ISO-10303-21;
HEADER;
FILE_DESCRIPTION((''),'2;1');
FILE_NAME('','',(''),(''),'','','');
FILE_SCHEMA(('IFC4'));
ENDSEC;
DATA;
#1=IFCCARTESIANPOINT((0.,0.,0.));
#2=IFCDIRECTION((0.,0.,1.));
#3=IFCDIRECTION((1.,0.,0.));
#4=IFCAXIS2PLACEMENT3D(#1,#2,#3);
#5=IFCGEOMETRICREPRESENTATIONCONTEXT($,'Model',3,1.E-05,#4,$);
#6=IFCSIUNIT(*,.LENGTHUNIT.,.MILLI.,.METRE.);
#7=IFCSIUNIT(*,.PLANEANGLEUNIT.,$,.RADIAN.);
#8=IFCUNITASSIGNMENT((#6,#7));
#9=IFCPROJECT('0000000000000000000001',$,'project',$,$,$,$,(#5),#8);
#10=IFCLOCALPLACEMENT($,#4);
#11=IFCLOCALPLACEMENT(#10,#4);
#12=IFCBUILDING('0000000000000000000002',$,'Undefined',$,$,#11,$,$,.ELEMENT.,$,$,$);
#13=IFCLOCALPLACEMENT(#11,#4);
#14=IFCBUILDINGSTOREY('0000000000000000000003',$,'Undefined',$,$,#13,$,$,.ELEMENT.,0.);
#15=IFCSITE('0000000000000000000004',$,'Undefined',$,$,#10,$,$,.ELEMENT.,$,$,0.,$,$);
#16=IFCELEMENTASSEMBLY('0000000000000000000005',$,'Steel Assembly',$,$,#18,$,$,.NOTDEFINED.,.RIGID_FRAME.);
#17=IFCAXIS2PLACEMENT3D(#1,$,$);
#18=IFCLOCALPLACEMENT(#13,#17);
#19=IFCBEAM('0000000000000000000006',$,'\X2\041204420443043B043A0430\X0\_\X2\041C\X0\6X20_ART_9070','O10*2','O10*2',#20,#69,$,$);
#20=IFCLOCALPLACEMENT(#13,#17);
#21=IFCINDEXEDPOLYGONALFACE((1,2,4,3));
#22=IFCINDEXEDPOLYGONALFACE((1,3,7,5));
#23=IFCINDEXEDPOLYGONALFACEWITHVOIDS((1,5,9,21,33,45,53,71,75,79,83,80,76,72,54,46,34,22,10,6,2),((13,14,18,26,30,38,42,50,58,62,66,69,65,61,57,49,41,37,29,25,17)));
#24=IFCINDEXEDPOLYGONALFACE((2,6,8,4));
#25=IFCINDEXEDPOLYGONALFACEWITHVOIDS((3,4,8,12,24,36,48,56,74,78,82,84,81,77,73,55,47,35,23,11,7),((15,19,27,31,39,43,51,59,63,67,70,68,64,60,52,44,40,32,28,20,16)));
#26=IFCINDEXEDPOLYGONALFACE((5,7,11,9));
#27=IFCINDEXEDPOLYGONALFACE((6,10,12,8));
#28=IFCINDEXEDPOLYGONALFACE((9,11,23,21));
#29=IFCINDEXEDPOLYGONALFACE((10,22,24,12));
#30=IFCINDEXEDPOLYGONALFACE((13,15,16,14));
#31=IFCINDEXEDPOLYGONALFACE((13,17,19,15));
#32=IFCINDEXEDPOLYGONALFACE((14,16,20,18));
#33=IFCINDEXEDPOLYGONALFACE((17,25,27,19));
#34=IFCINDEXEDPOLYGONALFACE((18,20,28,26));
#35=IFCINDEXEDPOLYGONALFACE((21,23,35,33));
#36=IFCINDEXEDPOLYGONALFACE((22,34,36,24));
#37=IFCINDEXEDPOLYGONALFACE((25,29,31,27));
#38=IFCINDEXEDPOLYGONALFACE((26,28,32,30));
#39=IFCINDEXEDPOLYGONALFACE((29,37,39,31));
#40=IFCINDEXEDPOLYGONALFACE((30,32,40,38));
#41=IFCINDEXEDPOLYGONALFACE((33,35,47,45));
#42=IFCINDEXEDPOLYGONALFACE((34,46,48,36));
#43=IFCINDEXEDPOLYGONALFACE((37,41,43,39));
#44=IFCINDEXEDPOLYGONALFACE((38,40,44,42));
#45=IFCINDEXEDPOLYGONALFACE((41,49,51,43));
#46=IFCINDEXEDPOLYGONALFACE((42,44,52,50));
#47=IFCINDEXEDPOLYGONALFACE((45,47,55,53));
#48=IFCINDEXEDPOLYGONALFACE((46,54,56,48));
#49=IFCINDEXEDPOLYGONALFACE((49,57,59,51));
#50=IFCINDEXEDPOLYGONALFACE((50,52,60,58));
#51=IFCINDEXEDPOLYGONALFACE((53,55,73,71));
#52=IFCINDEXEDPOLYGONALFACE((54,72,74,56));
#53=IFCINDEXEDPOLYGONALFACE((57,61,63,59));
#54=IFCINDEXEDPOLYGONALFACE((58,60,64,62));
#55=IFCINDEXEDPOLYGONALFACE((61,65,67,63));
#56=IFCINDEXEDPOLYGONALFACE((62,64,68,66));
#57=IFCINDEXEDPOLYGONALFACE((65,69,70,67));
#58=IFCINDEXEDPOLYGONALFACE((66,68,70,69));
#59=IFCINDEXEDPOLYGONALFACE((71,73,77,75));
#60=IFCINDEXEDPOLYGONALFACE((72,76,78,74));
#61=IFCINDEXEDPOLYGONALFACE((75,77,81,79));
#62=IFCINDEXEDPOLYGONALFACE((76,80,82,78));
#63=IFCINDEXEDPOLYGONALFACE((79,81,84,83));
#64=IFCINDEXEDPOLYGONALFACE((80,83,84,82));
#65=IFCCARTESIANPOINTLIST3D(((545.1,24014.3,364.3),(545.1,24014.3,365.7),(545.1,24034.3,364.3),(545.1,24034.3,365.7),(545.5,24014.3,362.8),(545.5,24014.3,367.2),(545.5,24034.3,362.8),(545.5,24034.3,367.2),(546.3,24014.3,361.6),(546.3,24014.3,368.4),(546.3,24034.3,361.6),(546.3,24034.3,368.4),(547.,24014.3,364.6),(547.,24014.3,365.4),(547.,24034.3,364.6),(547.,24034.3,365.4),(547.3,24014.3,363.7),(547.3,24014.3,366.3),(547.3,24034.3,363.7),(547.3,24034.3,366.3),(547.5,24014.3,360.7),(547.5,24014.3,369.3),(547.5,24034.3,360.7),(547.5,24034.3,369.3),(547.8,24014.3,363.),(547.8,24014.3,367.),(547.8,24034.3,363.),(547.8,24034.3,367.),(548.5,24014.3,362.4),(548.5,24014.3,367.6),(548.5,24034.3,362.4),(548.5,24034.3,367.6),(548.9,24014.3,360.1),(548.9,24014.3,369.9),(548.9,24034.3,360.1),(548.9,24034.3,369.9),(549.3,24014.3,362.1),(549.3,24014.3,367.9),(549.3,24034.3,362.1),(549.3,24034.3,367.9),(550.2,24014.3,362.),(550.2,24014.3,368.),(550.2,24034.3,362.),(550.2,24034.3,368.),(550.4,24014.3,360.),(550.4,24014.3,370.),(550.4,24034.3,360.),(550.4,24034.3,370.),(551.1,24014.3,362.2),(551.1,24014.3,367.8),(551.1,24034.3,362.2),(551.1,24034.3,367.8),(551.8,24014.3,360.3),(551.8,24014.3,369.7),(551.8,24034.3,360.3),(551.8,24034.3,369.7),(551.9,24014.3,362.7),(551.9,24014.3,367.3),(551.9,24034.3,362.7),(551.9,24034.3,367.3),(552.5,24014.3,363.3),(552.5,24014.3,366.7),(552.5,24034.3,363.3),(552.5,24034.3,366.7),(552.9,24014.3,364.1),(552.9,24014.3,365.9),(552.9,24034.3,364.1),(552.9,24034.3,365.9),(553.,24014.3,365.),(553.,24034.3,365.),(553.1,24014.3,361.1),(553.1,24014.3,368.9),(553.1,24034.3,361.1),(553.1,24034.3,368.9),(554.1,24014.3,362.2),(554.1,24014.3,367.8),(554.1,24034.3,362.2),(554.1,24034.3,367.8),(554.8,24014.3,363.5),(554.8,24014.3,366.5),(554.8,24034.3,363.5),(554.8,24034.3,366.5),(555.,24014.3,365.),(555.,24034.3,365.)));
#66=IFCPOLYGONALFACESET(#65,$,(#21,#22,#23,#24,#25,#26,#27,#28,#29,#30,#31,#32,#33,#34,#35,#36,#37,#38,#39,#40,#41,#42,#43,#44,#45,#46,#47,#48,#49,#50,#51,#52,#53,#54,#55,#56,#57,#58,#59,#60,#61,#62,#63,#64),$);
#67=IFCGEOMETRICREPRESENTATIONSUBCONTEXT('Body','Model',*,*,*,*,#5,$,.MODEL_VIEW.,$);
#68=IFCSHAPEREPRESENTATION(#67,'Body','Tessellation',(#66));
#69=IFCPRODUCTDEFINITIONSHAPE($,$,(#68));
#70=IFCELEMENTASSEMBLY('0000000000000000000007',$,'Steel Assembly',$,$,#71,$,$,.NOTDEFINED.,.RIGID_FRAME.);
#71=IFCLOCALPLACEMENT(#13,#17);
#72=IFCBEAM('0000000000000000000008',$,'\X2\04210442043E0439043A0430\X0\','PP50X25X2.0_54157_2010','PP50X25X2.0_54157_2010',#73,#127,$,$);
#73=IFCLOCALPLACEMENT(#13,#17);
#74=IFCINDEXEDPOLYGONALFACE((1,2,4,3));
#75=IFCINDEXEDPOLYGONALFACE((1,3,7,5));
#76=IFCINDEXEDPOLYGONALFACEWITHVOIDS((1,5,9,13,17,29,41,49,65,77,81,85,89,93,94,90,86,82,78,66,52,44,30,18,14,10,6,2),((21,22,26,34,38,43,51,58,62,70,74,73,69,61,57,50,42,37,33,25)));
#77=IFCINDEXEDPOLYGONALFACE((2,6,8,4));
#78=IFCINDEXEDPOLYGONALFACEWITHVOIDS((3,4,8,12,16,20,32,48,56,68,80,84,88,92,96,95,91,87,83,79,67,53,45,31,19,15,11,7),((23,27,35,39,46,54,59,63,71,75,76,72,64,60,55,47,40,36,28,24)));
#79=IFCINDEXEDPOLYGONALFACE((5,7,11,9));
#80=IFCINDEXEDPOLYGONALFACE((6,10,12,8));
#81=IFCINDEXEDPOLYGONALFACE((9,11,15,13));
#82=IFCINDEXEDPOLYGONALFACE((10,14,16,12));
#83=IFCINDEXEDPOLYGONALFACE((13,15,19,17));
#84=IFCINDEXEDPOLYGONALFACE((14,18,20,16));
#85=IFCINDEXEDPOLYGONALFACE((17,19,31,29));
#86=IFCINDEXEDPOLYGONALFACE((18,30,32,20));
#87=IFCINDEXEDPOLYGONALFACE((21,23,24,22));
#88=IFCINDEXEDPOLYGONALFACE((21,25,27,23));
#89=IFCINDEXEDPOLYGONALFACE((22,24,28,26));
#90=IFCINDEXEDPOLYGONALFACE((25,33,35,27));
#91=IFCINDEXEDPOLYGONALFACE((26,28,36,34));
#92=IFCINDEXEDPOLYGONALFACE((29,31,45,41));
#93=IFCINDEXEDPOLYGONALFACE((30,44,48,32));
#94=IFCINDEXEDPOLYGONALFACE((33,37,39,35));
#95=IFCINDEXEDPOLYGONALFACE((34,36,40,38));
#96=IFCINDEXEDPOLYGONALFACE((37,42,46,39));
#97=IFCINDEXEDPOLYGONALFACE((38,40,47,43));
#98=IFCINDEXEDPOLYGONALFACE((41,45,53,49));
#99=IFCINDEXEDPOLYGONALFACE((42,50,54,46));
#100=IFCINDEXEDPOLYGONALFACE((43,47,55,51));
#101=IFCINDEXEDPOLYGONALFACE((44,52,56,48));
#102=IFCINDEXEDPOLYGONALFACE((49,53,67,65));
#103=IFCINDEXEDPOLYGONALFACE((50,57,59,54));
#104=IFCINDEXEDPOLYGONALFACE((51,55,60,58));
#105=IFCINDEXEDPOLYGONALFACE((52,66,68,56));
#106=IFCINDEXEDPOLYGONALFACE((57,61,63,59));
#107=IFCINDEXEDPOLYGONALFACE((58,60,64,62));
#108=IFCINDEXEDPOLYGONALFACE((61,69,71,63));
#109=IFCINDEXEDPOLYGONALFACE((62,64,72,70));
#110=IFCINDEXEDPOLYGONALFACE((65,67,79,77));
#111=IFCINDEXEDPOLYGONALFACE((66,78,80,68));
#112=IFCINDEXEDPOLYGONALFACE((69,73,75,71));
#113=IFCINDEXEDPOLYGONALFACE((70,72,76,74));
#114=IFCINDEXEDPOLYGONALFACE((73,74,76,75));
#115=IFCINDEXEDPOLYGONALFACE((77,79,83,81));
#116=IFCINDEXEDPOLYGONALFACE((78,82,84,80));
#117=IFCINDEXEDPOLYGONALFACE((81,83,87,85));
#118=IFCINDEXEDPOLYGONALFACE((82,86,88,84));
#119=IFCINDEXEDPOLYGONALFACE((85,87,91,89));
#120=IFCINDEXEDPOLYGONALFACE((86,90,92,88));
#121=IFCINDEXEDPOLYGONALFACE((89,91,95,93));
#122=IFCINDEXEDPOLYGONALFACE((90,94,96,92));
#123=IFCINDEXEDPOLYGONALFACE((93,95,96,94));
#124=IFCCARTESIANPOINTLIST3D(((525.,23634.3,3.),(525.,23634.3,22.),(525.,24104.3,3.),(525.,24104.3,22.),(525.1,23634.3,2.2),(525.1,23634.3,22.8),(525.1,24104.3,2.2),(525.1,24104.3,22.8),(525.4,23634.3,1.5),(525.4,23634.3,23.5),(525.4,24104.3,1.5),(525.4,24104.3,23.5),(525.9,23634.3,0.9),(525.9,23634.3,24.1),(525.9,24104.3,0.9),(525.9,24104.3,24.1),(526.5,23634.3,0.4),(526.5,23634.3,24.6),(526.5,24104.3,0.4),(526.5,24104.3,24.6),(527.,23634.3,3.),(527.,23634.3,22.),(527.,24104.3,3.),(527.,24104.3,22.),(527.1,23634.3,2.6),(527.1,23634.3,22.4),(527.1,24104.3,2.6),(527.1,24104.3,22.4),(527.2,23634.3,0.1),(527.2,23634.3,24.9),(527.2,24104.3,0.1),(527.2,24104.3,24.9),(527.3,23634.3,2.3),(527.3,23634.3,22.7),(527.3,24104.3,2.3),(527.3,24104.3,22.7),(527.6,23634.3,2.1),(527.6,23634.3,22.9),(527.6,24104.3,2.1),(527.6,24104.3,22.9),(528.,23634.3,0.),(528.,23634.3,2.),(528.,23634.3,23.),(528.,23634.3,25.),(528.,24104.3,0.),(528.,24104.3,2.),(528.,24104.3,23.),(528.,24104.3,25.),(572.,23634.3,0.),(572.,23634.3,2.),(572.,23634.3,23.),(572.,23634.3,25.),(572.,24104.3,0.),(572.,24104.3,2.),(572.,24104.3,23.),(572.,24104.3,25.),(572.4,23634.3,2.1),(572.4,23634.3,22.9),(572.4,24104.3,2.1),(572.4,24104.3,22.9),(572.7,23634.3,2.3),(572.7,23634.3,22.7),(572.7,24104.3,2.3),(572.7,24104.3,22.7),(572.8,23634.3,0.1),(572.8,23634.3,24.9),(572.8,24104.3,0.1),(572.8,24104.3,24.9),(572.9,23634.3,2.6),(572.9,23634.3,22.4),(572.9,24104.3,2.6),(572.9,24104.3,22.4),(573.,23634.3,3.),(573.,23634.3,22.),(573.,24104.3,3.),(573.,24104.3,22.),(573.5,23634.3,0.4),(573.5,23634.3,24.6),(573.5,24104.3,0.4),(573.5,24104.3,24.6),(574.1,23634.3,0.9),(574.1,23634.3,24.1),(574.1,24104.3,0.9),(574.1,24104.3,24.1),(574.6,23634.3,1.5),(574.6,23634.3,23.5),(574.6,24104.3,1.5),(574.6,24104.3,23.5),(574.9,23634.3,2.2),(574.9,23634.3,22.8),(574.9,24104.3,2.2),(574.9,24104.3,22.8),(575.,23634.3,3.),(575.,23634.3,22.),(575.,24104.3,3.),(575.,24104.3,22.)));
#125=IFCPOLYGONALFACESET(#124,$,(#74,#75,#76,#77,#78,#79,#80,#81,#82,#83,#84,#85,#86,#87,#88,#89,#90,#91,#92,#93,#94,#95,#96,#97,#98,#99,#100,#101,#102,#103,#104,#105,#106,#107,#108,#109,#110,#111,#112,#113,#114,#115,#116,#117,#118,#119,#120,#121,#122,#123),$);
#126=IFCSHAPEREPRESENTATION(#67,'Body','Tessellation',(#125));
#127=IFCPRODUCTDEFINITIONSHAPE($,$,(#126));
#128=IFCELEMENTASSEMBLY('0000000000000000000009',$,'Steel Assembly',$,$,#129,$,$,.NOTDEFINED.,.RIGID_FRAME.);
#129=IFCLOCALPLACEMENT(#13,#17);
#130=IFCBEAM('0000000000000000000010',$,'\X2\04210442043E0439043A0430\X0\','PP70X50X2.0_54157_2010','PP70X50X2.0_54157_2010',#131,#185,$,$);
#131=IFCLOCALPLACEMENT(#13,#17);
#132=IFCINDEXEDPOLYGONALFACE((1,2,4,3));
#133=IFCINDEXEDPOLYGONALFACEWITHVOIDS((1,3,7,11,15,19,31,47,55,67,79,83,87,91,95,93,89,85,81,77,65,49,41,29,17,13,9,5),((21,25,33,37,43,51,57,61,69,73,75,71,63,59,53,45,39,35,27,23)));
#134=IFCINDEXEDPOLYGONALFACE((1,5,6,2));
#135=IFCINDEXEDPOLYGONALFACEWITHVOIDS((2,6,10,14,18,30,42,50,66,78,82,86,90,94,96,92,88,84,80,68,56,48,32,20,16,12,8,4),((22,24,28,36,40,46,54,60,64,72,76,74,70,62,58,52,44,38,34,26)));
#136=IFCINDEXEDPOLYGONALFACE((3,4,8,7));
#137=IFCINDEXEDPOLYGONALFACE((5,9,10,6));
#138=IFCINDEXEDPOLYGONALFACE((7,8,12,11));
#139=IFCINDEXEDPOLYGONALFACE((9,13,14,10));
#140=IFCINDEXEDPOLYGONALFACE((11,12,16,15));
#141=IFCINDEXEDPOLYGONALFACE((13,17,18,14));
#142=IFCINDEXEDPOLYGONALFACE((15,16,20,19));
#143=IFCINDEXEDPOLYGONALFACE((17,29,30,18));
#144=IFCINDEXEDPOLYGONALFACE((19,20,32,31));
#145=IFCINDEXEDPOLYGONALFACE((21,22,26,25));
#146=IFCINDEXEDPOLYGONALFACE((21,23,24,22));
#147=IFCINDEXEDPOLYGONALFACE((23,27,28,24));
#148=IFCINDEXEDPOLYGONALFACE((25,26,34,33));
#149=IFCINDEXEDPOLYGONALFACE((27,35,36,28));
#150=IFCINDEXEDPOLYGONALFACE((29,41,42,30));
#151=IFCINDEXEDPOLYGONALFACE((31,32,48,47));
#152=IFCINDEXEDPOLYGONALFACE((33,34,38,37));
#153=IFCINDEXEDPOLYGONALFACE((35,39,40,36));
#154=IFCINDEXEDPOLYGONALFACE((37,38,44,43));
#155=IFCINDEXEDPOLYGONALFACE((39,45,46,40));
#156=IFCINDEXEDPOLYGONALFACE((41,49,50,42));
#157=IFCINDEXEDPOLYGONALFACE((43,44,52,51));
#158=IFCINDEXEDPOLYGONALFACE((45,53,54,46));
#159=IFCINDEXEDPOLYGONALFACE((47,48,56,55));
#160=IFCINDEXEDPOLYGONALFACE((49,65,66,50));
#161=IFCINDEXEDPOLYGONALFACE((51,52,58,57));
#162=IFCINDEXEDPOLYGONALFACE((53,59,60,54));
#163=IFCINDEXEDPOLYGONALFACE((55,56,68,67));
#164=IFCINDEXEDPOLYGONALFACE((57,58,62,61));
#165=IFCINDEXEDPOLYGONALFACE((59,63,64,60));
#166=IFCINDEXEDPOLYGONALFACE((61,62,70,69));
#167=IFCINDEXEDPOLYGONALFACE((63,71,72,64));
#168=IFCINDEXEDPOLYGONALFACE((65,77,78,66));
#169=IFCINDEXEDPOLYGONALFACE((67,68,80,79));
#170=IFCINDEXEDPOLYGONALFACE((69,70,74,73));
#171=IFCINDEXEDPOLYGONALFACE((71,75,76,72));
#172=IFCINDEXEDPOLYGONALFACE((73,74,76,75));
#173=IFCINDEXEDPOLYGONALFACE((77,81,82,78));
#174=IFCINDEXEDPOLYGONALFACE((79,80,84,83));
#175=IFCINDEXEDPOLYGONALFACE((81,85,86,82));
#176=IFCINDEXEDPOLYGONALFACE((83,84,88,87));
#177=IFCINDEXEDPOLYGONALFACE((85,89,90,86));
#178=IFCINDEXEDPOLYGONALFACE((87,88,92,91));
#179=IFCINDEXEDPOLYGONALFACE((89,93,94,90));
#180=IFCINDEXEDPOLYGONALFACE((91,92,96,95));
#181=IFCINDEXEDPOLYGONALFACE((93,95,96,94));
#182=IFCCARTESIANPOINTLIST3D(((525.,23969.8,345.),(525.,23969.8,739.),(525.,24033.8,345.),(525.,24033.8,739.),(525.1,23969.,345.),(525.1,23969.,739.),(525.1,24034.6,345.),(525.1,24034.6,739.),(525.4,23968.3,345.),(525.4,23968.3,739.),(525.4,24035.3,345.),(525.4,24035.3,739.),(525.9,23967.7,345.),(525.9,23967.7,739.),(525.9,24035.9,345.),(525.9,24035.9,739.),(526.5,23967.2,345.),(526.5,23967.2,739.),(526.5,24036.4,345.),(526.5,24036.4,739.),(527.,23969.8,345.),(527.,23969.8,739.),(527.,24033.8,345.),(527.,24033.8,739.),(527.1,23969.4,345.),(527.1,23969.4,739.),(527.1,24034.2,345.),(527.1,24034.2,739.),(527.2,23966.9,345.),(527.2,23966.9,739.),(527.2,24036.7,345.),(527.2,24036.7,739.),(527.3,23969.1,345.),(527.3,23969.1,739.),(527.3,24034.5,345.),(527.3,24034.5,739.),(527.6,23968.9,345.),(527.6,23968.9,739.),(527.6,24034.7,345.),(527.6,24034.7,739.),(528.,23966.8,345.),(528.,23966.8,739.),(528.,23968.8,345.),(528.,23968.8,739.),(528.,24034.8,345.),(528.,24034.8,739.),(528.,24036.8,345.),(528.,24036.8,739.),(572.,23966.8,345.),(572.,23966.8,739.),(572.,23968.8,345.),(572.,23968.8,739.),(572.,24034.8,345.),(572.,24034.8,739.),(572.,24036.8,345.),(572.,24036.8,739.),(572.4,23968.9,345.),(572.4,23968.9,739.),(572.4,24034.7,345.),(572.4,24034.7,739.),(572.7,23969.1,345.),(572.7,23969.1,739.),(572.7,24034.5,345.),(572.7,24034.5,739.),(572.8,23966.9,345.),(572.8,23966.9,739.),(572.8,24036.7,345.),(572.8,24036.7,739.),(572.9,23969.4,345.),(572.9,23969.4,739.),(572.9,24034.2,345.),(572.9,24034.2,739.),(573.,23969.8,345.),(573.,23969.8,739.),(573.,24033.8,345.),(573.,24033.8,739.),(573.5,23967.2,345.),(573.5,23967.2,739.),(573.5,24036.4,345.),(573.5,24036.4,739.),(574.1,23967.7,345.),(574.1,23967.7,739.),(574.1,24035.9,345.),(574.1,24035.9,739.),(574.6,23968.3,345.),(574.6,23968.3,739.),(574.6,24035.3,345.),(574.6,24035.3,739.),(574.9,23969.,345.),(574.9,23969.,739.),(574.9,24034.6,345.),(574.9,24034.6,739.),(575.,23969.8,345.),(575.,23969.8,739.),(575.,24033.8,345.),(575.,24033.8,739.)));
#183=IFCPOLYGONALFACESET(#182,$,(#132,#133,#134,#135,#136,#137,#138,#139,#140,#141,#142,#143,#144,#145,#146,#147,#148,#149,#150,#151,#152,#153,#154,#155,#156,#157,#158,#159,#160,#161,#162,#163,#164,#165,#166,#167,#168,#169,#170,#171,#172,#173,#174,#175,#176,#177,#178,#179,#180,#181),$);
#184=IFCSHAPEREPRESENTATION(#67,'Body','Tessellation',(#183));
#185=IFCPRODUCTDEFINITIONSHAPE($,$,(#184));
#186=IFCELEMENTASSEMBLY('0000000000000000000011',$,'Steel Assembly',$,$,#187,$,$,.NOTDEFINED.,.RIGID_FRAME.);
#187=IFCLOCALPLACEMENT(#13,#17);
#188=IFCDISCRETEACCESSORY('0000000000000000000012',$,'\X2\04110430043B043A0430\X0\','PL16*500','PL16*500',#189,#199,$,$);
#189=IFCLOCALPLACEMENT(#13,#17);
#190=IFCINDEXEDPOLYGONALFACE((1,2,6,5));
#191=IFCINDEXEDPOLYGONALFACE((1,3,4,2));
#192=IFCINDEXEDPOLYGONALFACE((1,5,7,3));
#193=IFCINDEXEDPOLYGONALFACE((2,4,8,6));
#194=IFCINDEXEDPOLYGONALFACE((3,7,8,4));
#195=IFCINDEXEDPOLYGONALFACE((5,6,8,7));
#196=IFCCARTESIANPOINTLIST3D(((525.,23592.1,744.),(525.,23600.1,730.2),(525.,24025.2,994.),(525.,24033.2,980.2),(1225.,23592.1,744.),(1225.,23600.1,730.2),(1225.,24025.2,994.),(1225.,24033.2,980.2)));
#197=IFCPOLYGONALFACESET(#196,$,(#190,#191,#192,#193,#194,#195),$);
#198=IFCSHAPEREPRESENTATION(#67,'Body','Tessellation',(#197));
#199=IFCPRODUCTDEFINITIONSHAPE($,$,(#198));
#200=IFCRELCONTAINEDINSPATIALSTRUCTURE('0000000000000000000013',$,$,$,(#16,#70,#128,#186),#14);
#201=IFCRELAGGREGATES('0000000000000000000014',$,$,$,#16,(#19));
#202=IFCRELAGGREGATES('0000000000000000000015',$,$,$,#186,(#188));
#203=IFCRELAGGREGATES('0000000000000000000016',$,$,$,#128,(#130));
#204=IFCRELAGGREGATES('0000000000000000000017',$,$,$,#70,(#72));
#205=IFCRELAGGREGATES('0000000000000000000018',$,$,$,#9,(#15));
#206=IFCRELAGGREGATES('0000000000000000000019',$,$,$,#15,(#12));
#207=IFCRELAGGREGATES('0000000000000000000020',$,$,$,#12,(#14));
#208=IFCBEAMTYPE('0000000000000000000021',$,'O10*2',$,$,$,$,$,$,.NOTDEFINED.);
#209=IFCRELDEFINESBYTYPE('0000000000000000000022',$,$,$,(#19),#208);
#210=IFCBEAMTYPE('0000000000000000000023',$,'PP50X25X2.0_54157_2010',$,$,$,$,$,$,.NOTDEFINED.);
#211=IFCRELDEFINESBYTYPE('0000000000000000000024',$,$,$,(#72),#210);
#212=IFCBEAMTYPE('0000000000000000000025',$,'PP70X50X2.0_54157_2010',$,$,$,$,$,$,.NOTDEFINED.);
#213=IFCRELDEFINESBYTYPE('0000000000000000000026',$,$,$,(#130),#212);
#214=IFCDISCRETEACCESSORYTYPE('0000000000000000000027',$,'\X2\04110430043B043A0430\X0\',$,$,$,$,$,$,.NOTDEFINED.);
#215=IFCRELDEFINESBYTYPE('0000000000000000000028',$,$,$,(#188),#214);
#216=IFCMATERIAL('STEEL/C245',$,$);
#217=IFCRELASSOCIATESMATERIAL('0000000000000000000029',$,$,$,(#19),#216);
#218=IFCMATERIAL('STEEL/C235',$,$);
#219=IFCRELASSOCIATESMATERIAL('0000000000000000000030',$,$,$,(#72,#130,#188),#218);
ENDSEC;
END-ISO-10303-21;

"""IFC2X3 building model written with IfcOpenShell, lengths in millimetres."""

from ifc_helpers import new_model, si_unit, frame, origin_with_axes, origin_2d_with_axis, place, context, subcontext, project, spatial, polyline, hollow_rectangle, hollow_circle, outline, extrude, material, type_object, element, aggregate, save


model = new_model("IFC2X3")

# Units and contexts
model_context = context("Model", 3, precision=1e-05, world=origin_with_axes())
body_context = subcontext(model_context, "Body", "Model", "MODEL_VIEW")
ifc_project = project(units=[si_unit("LENGTHUNIT", "METRE", prefix="MILLI"), si_unit("PLANEANGLEUNIT", "RADIAN")], contexts=[model_context])

# Site, building, storey
site_placement = place(None, origin_with_axes())
site = spatial("IfcSite", under=ifc_project, at=site_placement, Name="Undefined", CompositionType="ELEMENT", RefElevation=0.0)
building_placement = place(site_placement, origin_with_axes())
building = spatial("IfcBuilding", under=site, at=building_placement, Name="Undefined", CompositionType="ELEMENT")
storey_placement = place(building_placement, origin_with_axes())
storey = spatial("IfcBuildingStorey", under=building, at=storey_placement, Name="Undefined", CompositionType="ELEMENT", Elevation=0.0)

# Element assemblies, beams
ifc_material_1 = material(Name="STEEL/C235")
ifc_material_2 = material(Name="STEEL/C245")
beam_type_1 = type_object("IfcBeamType", Name="O10*2", PredefinedType="NOTDEFINED")
assembly_1_placement = place(storey_placement, origin_with_axes())
assembly_1 = element("IfcElementAssembly", 1, at=assembly_1_placement, inside=storey, Name="Steel Assembly", AssemblyPlace="NOTDEFINED", PredefinedType="RIGID_FRAME")
beam_1_placement = place(assembly_1_placement, frame((550.0, 24014.3, 365.0), z_axis=(0.0, 0.0, 1.0), x_axis=(0.0, 1.0, 0.0)))
beam_1 = element("IfcBeam", 2, at=beam_1_placement, type_object=beam_type_1, material=ifc_material_2, Name="Втулка_М6X20_ART_9070", Description="O10*2", ObjectType="O10*2", context=body_context, shape_type="SweptSolid", body=[
    extrude(hollow_circle(Radius=5.0, WallThickness=2.0, at=origin_2d_with_axis()), frame((20.0, 0.0, 0.0), z_axis=(-1.0, 0.0, 0.0), x_axis=(0.0, -1.0, 0.0)), (0.0, 0.0, 1.0), 20.0),
])
aggregate(assembly_1, [beam_1])
assembly_2_placement = place(storey_placement, origin_with_axes())
assembly_2 = element("IfcElementAssembly", 3, at=assembly_2_placement, inside=storey, Name="Steel Assembly", AssemblyPlace="NOTDEFINED", PredefinedType="RIGID_FRAME")
beam_type_2 = type_object("IfcBeamType", Name="PP50X25X2.0_54157_2010", PredefinedType="NOTDEFINED")
beam_2_placement = place(assembly_2_placement, frame((550.0, 24104.3, 12.5), z_axis=(-1.0, 0.0, 0.0), x_axis=(0.0, -1.0, 0.0)))
beam_2 = element("IfcBeam", 4, at=beam_2_placement, type_object=beam_type_2, material=ifc_material_1, Name="Стойка", Description="PP50X25X2.0_54157_2010", ObjectType="PP50X25X2.0_54157_2010", context=body_context, shape_type="SweptSolid", body=[
    extrude(hollow_rectangle(XDim=25.0, YDim=50.0, WallThickness=2.0, InnerFilletRadius=1.0, OuterFilletRadius=3.0, at=origin_2d_with_axis()), frame((470.0, 0.0, 0.0), z_axis=(-1.0, 0.0, 0.0), x_axis=(0.0, -1.0, 0.0)), (0.0, 0.0, 1.0), 470.0),
])
assembly_3_placement = place(storey_placement, origin_with_axes())
assembly_3 = element("IfcElementAssembly", 5, at=assembly_3_placement, inside=storey, Name="Steel Assembly", AssemblyPlace="NOTDEFINED", PredefinedType="RIGID_FRAME")
beam_type_3 = type_object("IfcBeamType", Name="PP70X50X2.0_54157_2010", PredefinedType="NOTDEFINED")
beam_3_placement = place(assembly_3_placement, frame((550.0, 24001.8, 739.0), z_axis=(0.0, -1.0, 0.0), x_axis=(0.0, 0.0, -1.0)))
beam_3 = element("IfcBeam", 6, at=beam_3_placement, type_object=beam_type_3, material=ifc_material_1, Name="Стойка", Description="PP70X50X2.0_54157_2010", ObjectType="PP70X50X2.0_54157_2010", context=body_context, shape_type="SweptSolid", body=[
    extrude(hollow_rectangle(XDim=50.0, YDim=70.0, WallThickness=2.0, InnerFilletRadius=1.0, OuterFilletRadius=3.0, at=origin_2d_with_axis()), frame((394.0, 0.0, 0.0), z_axis=(-1.0, 0.0, 0.0), x_axis=(0.0, -1.0, 0.0)), (0.0, 0.0, 1.0), 394.0),
])

# Element assembly, discrete accessory
assembly_4_placement = place(storey_placement, origin_with_axes())
assembly_4 = element("IfcElementAssembly", 7, at=assembly_4_placement, inside=storey, Name="Steel Assembly", AssemblyPlace="NOTDEFINED", PredefinedType="RIGID_FRAME")
discrete_accessory_type_1 = type_object("IfcDiscreteAccessoryType", Name="Балка")
discrete_accessory_1_placement = place(assembly_4_placement, frame((525.0, 23812.7, 862.1), z_axis=(0.0, 0.5, -0.866025), x_axis=(1.0, 0.0, 0.0)))
discrete_accessory_1 = element("IfcDiscreteAccessory", 8, at=discrete_accessory_1_placement, type_object=discrete_accessory_type_1, material=ifc_material_1, Name="Балка", Description="PL16*500", ObjectType="PL16*500", context=body_context, shape_type="SweptSolid", body=[
    extrude(outline(polyline([(0.0, 250.0), (700.0, 250.0), (700.0, -250.0), (0.0, -250.0), (0.0, 250.0)])), frame((0.0, 0.0, -8.0), z_axis=(0.0, 0.0, 1.0), x_axis=(1.0, 0.0, 0.0)), (0.0, 0.0, 1.0), 16.0),
])
aggregate(assembly_4, [discrete_accessory_1])

aggregate(assembly_3, [beam_3])

aggregate(assembly_2, [beam_2])

save(model, "model.ifc")
